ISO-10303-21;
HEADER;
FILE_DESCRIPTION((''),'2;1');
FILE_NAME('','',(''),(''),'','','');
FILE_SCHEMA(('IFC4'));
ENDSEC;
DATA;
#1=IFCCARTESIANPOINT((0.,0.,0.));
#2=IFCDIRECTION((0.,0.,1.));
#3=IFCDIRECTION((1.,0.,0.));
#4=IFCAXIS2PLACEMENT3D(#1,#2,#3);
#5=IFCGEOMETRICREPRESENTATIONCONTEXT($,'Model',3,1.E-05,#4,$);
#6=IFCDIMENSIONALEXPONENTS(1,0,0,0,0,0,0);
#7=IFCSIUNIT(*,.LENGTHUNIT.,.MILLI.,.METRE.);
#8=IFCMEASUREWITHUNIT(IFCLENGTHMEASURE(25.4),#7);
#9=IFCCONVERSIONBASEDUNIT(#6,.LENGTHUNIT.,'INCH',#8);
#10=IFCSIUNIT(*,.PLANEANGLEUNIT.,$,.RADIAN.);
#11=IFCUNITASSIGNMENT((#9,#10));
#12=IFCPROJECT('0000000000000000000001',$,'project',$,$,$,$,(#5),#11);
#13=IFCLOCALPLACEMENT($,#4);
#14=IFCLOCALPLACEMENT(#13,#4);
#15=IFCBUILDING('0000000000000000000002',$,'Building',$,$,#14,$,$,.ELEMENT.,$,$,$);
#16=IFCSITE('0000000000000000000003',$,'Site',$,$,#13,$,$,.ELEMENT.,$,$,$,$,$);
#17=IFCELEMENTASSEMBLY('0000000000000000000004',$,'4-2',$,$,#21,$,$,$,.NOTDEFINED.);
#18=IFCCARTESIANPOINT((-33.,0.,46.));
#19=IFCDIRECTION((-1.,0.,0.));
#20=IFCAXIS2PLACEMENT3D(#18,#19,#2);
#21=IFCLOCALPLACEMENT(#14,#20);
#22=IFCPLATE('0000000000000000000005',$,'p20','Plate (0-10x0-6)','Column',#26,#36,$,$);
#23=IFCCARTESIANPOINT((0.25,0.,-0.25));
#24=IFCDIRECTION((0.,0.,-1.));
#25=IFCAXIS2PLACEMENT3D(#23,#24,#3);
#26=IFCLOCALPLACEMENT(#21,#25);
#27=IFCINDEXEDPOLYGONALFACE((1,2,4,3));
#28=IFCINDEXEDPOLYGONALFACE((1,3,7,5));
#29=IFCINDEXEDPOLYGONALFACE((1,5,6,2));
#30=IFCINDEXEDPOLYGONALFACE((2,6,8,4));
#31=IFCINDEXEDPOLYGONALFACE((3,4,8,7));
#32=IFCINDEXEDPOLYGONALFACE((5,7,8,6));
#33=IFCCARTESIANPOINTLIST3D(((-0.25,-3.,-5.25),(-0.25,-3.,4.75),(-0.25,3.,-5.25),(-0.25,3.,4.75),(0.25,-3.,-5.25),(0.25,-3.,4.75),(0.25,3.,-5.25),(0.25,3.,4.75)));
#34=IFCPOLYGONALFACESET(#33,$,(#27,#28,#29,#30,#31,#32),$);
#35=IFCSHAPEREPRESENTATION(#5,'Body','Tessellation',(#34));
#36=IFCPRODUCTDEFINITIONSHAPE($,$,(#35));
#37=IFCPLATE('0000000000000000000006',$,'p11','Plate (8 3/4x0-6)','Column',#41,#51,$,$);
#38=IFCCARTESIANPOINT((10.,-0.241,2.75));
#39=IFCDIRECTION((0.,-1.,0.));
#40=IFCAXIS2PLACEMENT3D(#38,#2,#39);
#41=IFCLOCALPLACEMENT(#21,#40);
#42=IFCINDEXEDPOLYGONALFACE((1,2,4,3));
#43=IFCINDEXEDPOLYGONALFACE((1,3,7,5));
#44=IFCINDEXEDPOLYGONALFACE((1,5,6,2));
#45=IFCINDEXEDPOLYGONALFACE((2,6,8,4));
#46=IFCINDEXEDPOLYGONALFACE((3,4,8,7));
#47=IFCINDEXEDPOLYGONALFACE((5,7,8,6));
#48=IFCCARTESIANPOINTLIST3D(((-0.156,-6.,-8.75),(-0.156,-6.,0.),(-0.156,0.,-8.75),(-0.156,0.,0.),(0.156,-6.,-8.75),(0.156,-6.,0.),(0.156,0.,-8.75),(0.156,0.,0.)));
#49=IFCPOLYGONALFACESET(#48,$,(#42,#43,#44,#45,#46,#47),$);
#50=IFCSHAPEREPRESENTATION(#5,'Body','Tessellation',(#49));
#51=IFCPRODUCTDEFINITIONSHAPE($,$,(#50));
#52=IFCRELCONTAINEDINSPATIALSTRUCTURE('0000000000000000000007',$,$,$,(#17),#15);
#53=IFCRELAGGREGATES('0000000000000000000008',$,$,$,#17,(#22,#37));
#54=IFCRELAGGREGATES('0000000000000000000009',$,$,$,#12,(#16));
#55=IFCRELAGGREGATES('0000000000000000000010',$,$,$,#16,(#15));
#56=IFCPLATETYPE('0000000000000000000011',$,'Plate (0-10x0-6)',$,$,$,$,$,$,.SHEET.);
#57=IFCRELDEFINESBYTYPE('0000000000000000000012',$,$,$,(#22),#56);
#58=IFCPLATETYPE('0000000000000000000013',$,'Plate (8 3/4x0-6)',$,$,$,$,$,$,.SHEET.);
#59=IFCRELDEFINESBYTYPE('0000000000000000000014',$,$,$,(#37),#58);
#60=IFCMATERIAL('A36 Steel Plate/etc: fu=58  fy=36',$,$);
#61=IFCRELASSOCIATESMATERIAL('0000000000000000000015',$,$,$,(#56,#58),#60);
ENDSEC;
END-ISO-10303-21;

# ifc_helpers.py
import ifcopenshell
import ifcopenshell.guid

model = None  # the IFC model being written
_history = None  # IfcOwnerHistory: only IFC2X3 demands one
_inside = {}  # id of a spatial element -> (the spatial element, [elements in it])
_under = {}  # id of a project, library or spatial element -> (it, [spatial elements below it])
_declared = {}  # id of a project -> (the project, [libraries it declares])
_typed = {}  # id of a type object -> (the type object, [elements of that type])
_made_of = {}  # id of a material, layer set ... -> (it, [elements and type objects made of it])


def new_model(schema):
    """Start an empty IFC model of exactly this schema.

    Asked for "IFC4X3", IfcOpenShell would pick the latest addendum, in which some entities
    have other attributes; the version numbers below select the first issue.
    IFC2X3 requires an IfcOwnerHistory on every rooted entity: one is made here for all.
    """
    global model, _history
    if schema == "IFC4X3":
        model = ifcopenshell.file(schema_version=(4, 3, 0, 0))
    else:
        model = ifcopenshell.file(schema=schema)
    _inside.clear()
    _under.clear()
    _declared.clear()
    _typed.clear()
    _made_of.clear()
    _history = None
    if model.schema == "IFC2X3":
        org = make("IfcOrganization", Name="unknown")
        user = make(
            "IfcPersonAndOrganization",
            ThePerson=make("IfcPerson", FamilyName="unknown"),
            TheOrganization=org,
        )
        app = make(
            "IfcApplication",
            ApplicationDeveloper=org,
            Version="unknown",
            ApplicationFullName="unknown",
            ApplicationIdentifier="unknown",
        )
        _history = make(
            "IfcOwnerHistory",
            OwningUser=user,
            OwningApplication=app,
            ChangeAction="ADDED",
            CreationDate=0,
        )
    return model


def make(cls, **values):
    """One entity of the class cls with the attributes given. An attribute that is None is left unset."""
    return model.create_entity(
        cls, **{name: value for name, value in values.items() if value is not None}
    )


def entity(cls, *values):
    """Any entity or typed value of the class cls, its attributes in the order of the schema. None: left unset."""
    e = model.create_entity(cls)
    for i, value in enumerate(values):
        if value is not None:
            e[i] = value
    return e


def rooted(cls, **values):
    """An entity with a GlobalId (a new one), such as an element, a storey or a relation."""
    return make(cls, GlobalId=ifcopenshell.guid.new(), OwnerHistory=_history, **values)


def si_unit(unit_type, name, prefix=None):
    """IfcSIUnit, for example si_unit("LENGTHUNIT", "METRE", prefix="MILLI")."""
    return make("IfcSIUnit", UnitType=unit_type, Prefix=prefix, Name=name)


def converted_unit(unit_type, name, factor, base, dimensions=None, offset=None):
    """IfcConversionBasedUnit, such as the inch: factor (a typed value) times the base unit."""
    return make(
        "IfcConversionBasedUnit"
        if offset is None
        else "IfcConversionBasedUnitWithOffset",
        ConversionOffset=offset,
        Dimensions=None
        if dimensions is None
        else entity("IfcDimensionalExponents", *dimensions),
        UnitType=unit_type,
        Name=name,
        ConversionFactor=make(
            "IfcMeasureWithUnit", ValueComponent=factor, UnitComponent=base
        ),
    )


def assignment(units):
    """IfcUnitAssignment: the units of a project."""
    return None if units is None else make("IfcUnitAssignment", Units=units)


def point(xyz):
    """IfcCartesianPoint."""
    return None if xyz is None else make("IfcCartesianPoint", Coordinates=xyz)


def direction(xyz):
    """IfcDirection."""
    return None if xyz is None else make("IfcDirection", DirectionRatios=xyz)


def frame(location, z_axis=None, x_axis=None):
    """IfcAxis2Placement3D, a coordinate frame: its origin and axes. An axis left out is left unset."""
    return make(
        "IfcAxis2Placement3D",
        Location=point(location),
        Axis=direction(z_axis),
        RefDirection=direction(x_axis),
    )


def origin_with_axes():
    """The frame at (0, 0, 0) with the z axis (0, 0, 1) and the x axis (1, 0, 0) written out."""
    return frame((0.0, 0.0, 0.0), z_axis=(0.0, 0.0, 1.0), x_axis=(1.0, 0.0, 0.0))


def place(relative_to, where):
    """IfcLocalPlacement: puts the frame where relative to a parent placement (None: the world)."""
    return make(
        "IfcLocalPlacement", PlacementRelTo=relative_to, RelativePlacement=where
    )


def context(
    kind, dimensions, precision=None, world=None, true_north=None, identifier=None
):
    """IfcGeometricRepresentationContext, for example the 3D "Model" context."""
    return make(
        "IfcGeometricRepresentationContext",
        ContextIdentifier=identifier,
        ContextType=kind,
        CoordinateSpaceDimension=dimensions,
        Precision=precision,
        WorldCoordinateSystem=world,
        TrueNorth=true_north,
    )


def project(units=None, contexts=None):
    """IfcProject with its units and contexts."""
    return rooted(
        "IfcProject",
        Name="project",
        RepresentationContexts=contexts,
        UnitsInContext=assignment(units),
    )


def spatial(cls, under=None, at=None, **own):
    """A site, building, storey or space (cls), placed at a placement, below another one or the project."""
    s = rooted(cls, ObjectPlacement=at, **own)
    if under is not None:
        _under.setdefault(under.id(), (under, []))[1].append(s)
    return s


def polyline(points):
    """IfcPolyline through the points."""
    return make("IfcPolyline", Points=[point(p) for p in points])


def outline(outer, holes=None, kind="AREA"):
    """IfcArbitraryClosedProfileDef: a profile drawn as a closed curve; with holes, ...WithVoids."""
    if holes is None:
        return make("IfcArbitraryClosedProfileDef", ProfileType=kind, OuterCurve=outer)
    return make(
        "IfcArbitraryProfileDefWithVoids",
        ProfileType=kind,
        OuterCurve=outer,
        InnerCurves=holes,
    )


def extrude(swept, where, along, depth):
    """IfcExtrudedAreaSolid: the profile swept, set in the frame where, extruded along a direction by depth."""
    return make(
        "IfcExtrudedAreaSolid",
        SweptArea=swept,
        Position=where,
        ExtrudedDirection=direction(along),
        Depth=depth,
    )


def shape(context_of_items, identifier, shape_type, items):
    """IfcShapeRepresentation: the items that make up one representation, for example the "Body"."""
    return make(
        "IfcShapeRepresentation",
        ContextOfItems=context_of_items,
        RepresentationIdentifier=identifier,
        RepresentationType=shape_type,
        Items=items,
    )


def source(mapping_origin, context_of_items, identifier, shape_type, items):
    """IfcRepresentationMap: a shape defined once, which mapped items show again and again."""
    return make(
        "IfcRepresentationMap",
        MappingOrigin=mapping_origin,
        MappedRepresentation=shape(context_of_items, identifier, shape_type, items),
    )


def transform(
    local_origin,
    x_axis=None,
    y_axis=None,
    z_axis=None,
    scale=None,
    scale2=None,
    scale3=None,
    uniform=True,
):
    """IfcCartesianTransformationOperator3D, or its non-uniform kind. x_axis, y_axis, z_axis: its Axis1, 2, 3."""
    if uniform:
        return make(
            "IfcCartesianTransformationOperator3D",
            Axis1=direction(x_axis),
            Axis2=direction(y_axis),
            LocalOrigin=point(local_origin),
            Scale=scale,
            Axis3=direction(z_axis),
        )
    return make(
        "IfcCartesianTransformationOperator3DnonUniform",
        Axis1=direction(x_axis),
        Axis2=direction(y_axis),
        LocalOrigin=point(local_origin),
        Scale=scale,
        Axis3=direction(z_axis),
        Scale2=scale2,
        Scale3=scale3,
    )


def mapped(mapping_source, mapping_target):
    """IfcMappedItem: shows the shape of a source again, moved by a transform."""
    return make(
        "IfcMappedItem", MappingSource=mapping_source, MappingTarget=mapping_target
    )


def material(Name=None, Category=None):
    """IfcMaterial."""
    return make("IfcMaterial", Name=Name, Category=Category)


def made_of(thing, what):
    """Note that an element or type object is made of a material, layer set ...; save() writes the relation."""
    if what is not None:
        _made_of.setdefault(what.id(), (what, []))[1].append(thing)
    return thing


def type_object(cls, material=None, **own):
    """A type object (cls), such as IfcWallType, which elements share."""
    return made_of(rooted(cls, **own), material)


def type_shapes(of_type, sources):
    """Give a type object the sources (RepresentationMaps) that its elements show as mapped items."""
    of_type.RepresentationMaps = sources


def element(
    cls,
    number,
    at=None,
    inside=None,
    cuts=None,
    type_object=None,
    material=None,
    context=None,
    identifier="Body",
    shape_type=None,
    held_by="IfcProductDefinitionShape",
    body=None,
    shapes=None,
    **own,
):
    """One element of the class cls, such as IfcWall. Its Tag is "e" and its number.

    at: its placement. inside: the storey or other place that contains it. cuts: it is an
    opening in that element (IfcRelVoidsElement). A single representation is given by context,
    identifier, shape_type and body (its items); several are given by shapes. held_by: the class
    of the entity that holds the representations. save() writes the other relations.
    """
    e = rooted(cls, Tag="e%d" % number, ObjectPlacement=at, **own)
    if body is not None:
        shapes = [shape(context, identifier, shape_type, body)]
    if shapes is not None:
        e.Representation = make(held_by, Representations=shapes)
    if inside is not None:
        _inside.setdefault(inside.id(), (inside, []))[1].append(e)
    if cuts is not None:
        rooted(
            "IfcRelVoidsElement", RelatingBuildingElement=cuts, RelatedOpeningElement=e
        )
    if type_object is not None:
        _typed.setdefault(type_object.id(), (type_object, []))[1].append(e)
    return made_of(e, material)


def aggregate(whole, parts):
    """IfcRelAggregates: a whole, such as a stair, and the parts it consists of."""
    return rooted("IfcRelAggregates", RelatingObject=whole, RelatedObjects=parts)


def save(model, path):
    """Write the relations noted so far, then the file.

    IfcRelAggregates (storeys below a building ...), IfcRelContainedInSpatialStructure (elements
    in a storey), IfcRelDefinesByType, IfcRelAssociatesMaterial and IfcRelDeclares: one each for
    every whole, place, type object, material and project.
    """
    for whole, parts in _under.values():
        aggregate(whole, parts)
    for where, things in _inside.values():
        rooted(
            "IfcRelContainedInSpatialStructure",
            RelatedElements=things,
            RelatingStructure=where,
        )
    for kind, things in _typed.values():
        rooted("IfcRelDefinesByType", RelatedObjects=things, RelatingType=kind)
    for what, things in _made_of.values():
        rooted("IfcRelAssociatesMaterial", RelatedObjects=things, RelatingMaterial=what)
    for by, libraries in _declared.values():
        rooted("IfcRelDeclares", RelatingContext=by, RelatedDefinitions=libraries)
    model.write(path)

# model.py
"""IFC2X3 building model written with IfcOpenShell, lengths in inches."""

from ifc_helpers import new_model, entity, si_unit, converted_unit, frame, origin_with_axes, place, context, project, spatial, polyline, outline, extrude, source, transform, mapped, material, type_object, type_shapes, element, aggregate, save


model = new_model("IFC2X3")

# Units and contexts
model_context = context("Model", 3, precision=1e-05, world=origin_with_axes())
ifc_project = project(units=[converted_unit("LENGTHUNIT", "INCH", entity("IfcLengthMeasure", 25.4), si_unit("LENGTHUNIT", "METRE", prefix="MILLI"), dimensions=[1, 0, 0, 0, 0, 0, 0]), si_unit("PLANEANGLEUNIT", "RADIAN")], contexts=[model_context])

# Site, building
site_placement = place(None, origin_with_axes())
site = spatial("IfcSite", under=ifc_project, at=site_placement, Name="Site", CompositionType="ELEMENT")
building_placement = place(site_placement, origin_with_axes())
building = spatial("IfcBuilding", under=site, at=building_placement, Name="Building", CompositionType="ELEMENT")

# Element assembly
assembly_1_placement = place(building_placement, frame((-33.0, 0.0, 46.0), z_axis=(-1.0, 0.0, 0.0), x_axis=(0.0, 0.0, 1.0)))
assembly_1 = element("IfcElementAssembly", 1, at=assembly_1_placement, inside=building, Name="4-2", PredefinedType="NOTDEFINED")

# Shared definitions
ifc_material_1 = material(Name="A36 Steel Plate/etc: fu=58  fy=36")

# Plates
plate_type_1 = type_object("IfcPlateType", Name="Plate (0-10x0-6)", PredefinedType="SHEET", material=ifc_material_1)
shared_shape_1 = source(origin_with_axes(), model_context, "Body", "SweptSolid", [
    extrude(outline(polyline([(3.0, -5.25), (-3.0, -5.25), (-3.0, 4.75), (3.0, 4.75), (3.0, -5.25)])), frame((-0.25, 0.0, 0.0), z_axis=(1.0, 0.0, 0.0), x_axis=(0.0, 1.0, 0.0)), (0.0, 0.0, 1.0), 0.5),
])
type_shapes(plate_type_1, [shared_shape_1])
plate_1_placement = place(assembly_1_placement, frame((0.25, 0.0, -0.25), z_axis=(0.0, 0.0, -1.0), x_axis=(1.0, 0.0, 0.0)))
plate_1 = element("IfcPlate", 2, at=plate_1_placement, type_object=plate_type_1, Name="p20", Description="Plate (0-10x0-6)", ObjectType="Column", context=model_context, shape_type="MappedRepresentation", body=[
    mapped(shared_shape_1, transform((0.0, 0.0, 0.0), scale=1.0)),
])
plate_type_2 = type_object("IfcPlateType", Name="Plate (8 3/4x0-6)", PredefinedType="SHEET", material=ifc_material_1)
shared_shape_2 = source(origin_with_axes(), model_context, "Body", "SweptSolid", [
    extrude(outline(polyline([(0.0, -8.75), (-6.0, -8.75), (-6.0, 0.0), (0.0, 0.0), (0.0, -8.75)])), frame((-0.156, 0.0, 0.0), z_axis=(1.0, 0.0, 0.0), x_axis=(0.0, 1.0, 0.0)), (0.0, 0.0, 1.0), 0.312),
])
type_shapes(plate_type_2, [shared_shape_2])
plate_2_placement = place(assembly_1_placement, frame((10.0, -0.241, 2.75), z_axis=(0.0, 0.0, 1.0), x_axis=(0.0, -1.0, 0.0)))
plate_2 = element("IfcPlate", 3, at=plate_2_placement, type_object=plate_type_2, Name="p11", Description="Plate (8 3/4x0-6)", ObjectType="Column", context=model_context, shape_type="MappedRepresentation", body=[
    mapped(shared_shape_2, transform((0.0, 0.0, 0.0), scale=1.0)),
])
aggregate(assembly_1, [plate_1, plate_2])

save(model, "model.ifc")
